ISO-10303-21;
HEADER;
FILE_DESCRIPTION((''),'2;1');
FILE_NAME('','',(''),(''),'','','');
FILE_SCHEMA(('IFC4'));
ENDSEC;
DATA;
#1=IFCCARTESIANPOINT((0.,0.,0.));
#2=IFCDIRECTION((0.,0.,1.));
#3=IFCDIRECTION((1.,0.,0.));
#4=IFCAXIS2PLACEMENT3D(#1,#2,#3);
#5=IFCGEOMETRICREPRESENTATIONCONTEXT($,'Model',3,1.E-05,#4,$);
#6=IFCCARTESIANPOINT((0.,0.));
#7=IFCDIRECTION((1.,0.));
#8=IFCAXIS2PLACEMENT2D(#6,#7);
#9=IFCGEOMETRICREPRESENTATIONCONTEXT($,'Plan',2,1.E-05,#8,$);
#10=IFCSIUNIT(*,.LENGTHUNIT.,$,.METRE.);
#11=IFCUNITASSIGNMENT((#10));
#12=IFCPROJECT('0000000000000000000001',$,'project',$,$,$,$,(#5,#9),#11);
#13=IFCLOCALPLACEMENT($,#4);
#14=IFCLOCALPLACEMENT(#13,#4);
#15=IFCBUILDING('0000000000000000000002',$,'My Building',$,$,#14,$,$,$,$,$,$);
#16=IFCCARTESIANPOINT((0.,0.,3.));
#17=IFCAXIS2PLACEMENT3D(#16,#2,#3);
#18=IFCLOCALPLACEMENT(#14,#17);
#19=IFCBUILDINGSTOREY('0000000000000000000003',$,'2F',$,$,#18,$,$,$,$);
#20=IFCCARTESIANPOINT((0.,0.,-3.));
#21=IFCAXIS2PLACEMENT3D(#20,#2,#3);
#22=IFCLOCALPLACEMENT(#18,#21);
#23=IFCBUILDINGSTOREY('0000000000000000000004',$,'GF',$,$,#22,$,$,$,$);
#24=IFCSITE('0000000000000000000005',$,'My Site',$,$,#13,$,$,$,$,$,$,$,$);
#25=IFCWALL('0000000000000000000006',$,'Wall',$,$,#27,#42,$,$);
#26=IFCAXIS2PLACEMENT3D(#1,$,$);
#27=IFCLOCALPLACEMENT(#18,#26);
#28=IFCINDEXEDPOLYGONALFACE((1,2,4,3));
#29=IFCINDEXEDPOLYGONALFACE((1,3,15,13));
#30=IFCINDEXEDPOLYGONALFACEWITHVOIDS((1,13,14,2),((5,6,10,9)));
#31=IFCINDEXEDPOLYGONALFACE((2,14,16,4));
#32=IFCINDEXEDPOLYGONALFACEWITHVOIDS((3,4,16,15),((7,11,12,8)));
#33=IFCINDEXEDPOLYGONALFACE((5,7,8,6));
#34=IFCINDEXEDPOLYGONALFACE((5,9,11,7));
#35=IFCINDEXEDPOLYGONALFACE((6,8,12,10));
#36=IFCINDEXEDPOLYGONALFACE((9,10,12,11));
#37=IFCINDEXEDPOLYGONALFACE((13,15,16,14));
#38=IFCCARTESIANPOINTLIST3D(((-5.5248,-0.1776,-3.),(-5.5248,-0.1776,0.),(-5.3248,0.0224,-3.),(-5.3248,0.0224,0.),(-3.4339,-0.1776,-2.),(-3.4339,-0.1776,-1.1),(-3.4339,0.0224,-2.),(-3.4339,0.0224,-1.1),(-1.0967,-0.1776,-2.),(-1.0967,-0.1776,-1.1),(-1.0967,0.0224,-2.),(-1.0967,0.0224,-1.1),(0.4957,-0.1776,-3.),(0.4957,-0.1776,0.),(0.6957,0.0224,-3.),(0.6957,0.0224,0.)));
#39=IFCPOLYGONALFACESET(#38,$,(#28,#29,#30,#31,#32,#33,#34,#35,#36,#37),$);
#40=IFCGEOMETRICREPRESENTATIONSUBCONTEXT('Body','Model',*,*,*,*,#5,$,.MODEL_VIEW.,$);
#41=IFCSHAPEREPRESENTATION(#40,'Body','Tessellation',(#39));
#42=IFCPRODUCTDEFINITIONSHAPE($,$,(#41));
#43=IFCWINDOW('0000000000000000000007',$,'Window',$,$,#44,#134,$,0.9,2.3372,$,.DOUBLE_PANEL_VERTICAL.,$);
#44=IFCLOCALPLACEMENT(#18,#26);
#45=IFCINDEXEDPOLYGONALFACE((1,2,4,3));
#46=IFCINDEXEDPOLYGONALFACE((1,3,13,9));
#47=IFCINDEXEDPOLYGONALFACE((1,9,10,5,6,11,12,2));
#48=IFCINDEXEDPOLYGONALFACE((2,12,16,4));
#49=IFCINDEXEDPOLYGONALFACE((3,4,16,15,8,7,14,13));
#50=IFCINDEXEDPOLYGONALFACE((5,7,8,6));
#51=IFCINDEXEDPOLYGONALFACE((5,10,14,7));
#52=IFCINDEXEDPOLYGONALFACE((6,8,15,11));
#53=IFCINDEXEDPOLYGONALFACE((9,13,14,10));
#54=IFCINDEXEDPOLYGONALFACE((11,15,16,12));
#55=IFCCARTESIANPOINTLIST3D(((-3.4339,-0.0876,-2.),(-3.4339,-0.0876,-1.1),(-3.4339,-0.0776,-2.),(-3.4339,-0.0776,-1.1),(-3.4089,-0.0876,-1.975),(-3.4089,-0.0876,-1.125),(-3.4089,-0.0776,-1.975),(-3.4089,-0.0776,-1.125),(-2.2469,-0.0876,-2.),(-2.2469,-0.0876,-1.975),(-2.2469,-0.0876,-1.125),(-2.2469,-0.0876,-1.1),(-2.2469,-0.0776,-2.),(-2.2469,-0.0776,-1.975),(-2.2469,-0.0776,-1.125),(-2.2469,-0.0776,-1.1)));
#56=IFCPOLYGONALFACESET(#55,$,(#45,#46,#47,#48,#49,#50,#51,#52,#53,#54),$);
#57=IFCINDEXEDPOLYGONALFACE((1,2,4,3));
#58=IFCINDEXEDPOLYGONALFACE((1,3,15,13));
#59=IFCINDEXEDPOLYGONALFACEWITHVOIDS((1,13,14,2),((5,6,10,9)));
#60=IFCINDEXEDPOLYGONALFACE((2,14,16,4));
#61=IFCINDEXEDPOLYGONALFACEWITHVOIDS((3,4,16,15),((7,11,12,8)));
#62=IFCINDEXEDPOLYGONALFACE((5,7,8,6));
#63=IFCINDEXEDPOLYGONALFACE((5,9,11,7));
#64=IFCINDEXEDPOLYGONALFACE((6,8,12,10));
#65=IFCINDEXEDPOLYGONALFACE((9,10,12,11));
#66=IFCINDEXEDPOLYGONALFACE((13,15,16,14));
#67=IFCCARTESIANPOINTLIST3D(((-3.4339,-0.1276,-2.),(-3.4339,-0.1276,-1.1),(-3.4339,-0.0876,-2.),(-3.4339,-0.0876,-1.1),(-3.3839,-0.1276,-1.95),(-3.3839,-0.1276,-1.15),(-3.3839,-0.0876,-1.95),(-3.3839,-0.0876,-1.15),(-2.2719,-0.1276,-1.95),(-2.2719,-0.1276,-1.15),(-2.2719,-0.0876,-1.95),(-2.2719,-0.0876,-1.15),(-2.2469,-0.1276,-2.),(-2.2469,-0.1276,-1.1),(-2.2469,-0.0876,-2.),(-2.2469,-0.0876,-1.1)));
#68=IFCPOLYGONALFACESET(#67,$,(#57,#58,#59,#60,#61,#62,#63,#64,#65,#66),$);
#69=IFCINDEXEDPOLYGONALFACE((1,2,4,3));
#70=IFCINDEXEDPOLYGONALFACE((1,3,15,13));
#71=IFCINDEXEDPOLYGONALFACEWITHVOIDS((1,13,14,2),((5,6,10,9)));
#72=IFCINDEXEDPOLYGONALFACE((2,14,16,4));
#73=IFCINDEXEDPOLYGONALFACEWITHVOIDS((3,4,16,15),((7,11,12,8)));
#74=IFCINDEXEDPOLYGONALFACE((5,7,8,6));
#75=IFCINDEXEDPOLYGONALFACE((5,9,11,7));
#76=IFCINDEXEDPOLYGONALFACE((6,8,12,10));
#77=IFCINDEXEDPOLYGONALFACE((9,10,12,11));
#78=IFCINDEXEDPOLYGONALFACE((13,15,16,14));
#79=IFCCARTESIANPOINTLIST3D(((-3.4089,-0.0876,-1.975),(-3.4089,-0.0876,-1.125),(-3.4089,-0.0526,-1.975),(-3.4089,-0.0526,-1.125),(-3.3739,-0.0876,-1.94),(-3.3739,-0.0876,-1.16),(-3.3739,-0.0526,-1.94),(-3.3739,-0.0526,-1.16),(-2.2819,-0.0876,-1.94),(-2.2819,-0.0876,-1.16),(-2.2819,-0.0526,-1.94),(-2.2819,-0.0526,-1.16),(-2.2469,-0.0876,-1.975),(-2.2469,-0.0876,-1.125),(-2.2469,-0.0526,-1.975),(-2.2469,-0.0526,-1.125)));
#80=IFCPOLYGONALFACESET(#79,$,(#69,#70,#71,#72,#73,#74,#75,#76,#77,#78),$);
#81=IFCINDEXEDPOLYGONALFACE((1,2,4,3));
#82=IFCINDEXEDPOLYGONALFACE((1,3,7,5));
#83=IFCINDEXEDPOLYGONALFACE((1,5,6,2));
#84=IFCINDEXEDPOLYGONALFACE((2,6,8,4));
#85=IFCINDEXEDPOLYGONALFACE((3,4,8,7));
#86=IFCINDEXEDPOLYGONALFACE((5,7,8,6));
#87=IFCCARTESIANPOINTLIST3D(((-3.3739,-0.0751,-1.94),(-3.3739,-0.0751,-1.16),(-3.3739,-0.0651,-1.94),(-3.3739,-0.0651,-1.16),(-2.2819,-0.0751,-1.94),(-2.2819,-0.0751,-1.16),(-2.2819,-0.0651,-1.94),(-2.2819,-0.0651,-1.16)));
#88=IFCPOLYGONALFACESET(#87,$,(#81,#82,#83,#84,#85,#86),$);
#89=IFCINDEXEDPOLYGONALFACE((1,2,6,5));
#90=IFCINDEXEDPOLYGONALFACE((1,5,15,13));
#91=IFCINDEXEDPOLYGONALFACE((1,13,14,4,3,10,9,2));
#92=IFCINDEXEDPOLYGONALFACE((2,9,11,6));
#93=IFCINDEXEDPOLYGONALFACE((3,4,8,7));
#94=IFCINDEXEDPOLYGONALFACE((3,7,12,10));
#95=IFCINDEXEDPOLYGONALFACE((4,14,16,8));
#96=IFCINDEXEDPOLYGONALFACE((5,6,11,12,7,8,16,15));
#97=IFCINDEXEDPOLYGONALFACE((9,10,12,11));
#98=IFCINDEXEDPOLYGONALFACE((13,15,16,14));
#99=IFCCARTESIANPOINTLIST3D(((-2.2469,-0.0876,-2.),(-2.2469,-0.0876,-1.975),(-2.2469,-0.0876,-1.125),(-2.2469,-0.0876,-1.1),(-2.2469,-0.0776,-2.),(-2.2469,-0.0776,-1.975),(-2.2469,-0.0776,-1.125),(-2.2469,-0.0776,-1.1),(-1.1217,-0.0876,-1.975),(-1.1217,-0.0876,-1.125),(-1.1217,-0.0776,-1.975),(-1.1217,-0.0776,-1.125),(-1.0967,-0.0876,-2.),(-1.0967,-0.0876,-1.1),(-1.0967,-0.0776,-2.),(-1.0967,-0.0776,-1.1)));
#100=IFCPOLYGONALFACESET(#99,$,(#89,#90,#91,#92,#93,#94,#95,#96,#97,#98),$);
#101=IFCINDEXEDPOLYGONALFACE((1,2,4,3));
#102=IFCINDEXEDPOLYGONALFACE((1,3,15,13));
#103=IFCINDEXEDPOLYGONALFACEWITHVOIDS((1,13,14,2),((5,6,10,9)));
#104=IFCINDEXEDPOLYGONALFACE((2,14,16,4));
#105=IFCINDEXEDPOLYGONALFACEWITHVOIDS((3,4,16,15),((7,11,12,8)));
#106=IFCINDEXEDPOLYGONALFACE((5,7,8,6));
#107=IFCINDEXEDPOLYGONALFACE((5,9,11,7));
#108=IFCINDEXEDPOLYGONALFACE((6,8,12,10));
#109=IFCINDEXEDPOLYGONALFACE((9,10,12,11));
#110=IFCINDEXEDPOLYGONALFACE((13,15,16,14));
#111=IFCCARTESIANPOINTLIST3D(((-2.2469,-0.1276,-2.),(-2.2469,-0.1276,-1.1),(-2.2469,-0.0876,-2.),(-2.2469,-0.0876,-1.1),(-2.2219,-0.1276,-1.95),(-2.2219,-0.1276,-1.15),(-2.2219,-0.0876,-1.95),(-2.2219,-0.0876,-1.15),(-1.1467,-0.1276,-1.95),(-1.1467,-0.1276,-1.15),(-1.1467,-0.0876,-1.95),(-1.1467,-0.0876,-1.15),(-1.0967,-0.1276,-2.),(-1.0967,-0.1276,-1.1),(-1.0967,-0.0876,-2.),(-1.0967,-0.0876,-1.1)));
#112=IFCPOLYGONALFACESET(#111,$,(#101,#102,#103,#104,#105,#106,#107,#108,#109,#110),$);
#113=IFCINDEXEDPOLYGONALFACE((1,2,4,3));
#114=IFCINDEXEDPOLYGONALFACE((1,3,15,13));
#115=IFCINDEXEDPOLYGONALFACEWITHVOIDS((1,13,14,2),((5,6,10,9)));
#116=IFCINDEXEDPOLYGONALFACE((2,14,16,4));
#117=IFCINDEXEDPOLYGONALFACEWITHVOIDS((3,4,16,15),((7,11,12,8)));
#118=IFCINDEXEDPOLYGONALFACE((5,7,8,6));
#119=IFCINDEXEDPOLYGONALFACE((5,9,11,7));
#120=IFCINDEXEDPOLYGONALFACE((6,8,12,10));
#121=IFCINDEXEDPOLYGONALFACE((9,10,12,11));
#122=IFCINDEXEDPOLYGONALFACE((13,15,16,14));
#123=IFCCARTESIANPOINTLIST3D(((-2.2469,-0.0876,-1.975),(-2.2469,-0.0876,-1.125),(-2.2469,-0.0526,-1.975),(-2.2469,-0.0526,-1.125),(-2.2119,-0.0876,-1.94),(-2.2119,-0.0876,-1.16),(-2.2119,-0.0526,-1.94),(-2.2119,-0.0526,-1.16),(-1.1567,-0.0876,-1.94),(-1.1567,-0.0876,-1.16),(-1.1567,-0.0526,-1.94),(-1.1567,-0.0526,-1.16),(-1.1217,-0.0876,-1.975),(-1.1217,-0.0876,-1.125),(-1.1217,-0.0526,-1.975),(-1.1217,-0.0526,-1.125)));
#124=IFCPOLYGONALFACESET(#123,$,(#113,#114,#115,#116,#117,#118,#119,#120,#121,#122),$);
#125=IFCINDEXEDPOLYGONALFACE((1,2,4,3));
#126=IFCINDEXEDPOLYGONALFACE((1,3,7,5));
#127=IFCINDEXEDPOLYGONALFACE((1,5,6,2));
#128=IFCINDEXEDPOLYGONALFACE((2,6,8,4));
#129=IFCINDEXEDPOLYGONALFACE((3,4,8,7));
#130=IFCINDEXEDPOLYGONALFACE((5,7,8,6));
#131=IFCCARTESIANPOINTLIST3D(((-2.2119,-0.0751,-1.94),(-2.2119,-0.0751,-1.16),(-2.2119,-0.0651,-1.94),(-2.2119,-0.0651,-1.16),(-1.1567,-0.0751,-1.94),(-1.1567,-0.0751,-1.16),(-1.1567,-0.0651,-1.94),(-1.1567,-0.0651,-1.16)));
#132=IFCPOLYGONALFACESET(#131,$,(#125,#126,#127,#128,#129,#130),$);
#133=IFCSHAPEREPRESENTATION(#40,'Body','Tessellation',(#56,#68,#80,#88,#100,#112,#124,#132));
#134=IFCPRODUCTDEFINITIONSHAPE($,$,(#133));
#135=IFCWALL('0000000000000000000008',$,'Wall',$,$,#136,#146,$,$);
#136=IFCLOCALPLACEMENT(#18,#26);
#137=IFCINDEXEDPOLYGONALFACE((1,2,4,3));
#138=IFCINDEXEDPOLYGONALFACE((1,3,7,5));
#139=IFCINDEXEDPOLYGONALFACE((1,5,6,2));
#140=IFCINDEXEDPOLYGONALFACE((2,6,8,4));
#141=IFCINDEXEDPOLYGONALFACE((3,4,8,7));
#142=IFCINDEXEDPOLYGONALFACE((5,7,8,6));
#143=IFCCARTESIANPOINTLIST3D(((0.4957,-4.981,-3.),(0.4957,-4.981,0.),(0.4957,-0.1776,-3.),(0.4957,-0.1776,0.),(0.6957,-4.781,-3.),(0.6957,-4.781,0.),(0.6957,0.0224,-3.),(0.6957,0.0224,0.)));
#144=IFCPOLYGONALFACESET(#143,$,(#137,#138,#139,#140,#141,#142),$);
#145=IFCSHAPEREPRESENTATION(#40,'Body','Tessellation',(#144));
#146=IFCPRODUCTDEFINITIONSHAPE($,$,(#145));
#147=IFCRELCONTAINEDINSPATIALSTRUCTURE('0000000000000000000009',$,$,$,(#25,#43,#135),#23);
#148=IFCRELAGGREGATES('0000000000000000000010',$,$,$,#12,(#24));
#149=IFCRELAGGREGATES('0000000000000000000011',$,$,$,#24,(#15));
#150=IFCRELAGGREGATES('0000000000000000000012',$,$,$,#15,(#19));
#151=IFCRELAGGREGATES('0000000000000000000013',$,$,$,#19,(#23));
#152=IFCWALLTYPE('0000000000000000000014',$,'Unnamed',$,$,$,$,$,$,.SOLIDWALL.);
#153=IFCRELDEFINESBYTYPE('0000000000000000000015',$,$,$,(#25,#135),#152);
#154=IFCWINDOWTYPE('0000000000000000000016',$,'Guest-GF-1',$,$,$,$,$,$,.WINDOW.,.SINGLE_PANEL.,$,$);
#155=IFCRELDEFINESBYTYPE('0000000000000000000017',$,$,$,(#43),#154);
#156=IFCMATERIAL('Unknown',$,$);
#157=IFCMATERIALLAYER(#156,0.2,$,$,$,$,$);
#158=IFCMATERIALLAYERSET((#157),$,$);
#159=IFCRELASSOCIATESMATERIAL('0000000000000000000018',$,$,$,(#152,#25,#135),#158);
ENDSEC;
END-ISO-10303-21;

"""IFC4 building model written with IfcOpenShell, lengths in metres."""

from ifc_helpers import new_model, entity, si_unit, frame, origin_with_axes, origin_2d_with_axis, place, context, subcontext, project, spatial, line, indexed_curve, outline, extrude, shape, source, transform, mapped, material, layer, layer_set, layer_usage, type_object, type_shapes, element, fill, save


model = new_model("IFC4")

# Units and contexts
model_context = context("Model", 3, precision=1e-05, world=origin_with_axes())
plan_context = context("Plan", 2, precision=1e-05, world=origin_2d_with_axis())
body_context_1 = subcontext(model_context, "Body", "Model", "MODEL_VIEW")
body_context_2 = subcontext(plan_context, "Body", "Plan", "PLAN_VIEW")
ifc_project = project(units=[si_unit("LENGTHUNIT", "METRE")], contexts=[model_context, plan_context])

# Site, building, storeys
site_placement = place(None, origin_with_axes())
site = spatial("IfcSite", under=ifc_project, at=site_placement, Name="My Site")
building_placement = place(site_placement, origin_with_axes())
building = spatial("IfcBuilding", under=site, at=building_placement, Name="My Building")
storey_1_placement = place(building_placement, frame((0.0, 0.0, 3.0), z_axis=(0.0, 0.0, 1.0), x_axis=(1.0, 0.0, 0.0)))
storey_1 = spatial("IfcBuildingStorey", under=building, at=storey_1_placement, Name="2F")
storey_2_placement = place(storey_1_placement, frame((0.0, 0.0, -3.0), z_axis=(0.0, 0.0, 1.0), x_axis=(1.0, 0.0, 0.0)))
storey_2 = spatial("IfcBuildingStorey", under=storey_1, at=storey_2_placement, Name="GF")

# Shared definitions
ifc_material = material(Name="Unknown")

# Shared definitions
ifc_layer_1 = layer(ifc_material, 0.2)
ifc_layer_set_1 = layer_set([ifc_layer_1])
wall_type = type_object("IfcWallType", Name="Unnamed", PredefinedType="SOLIDWALL", material=ifc_layer_set_1)

# Wall, opening, window
ifc_layer_usage_1 = layer_usage(ifc_layer_set_1, "AXIS2", "POSITIVE", 0.0)
wall_1_placement = place(storey_2_placement, frame((-5.5248, -0.1776, 0.0), z_axis=(0.0, 0.0, 1.0), x_axis=(1.0, 0.0, 0.0)))
wall_1 = element("IfcWall", 1, at=wall_1_placement, inside=storey_2, type_object=wall_type, material=ifc_layer_usage_1, Name="Wall", context=body_context_1, shape_type="SweptSolid", body=[
    extrude(outline(indexed_curve([(0.0, 0.0), (0.2, 0.2), (6.2205, 0.2), (6.0205, 0.0)], segments=[line(1, 2, 3, 4, 1)])), origin_with_axes(), (0.0, 0.0, 1.0), 3.0),
])
shared_shape_1 = source(origin_with_axes(), body_context_1, "Body", "SweptSolid", [
    extrude(outline(indexed_curve([(0.0, 0.0), (2.3372, 0.0), (2.3372, 0.9), (0.0, 0.9)], segments=[line(1, 2, 3, 4, 1)])), frame((0.0, -0.6, 0.0), z_axis=(0.0, -1.0, 0.0), x_axis=(1.0, 0.0, 0.0)), (0.0, 0.0, -1.0), 1.2),
])
opening_1_placement = place(wall_1_placement, frame((2.0909, 0.0, 1.0), z_axis=(0.0, 0.0, 1.0), x_axis=(1.0, 0.0, 0.0)))
opening_1 = element("IfcOpeningElement", 2, at=opening_1_placement, cuts=wall_1, PredefinedType="OPENING", context=body_context_1, shape_type="MappedRepresentation", body=[
    mapped(shared_shape_1, transform((0.0, 0.0, 0.0), x_axis=(1.0, 0.0, 0.0), y_axis=(0.0, 1.0, 0.0), z_axis=(0.0, 0.0, 1.0), scale=1.0)),
])
window_type_1 = type_object("IfcWindowType", Name="Guest-GF-1", PartitioningType="SINGLE_PANEL", PredefinedType="WINDOW")
shared_shape_2 = source(origin_with_axes(), body_context_1, "Body", "SweptSolid", [
    extrude(outline(indexed_curve([(1.187, 0.0), (0.0, 0.0), (0.0, 0.9), (1.187, 0.9), (1.187, 0.875), (0.025, 0.875), (0.025, 0.025), (1.187, 0.025)], segments=[line(1, 2, 3, 4, 5, 6, 7, 8, 1)])), frame((0.0, 0.09, 0.0), z_axis=(0.0, -1.0, 0.0), x_axis=(1.0, 0.0, 0.0)), (0.0, 0.0, -1.0), 0.01),
    extrude(outline(indexed_curve([(0.0, 0.0), (1.187, 0.0), (1.187, 0.9), (0.0, 0.9)], segments=[line(1, 2, 3, 4, 1)]), holes=[indexed_curve([(0.05, 0.05), (1.162, 0.05), (1.162, 0.85), (0.05, 0.85)], segments=[line(1, 2, 3, 4, 1)])]), frame((0.0, 0.05, 0.0), z_axis=(0.0, -1.0, 0.0), x_axis=(1.0, 0.0, 0.0)), (0.0, 0.0, -1.0), 0.04),
    extrude(outline(indexed_curve([(0.0, 0.0), (1.162, 0.0), (1.162, 0.85), (0.0, 0.85)], segments=[line(1, 2, 3, 4, 1)]), holes=[indexed_curve([(0.035, 0.035), (1.127, 0.035), (1.127, 0.815), (0.035, 0.815)], segments=[line(1, 2, 3, 4, 1)])]), frame((0.025, 0.09, 0.025), z_axis=(0.0, -1.0, 0.0), x_axis=(1.0, 0.0, 0.0)), (0.0, 0.0, -1.0), 0.035),
    extrude(outline(indexed_curve([(0.035, 0.035), (1.127, 0.035), (1.127, 0.815), (0.035, 0.815)], segments=[line(1, 2, 3, 4, 1)])), frame((0.025, 0.1025, 0.025), z_axis=(0.0, -1.0, 0.0), x_axis=(1.0, 0.0, 0.0)), (0.0, 0.0, -1.0), 0.01),
    extrude(outline(indexed_curve([(0.0, 0.9), (1.1502, 0.9), (1.1502, 0.0), (0.0, 0.0), (0.0, 0.025), (1.1252, 0.025), (1.1252, 0.875), (0.0, 0.875)], segments=[line(1, 2, 3, 4, 5, 6, 7, 8, 1)])), frame((1.187, 0.09, 0.0), z_axis=(0.0, -1.0, 0.0), x_axis=(1.0, 0.0, 0.0)), (0.0, 0.0, -1.0), 0.01),
    extrude(outline(indexed_curve([(0.0, 0.0), (1.1502, 0.0), (1.1502, 0.9), (0.0, 0.9)], segments=[line(1, 2, 3, 4, 1)]), holes=[indexed_curve([(0.025, 0.05), (1.1002, 0.05), (1.1002, 0.85), (0.025, 0.85)], segments=[line(1, 2, 3, 4, 1)])]), frame((1.187, 0.05, 0.0), z_axis=(0.0, -1.0, 0.0), x_axis=(1.0, 0.0, 0.0)), (0.0, 0.0, -1.0), 0.04),
    extrude(outline(indexed_curve([(0.0, 0.0), (1.1252, 0.0), (1.1252, 0.85), (0.0, 0.85)], segments=[line(1, 2, 3, 4, 1)]), holes=[indexed_curve([(0.035, 0.035), (1.0902, 0.035), (1.0902, 0.815), (0.035, 0.815)], segments=[line(1, 2, 3, 4, 1)])]), frame((1.187, 0.09, 0.025), z_axis=(0.0, -1.0, 0.0), x_axis=(1.0, 0.0, 0.0)), (0.0, 0.0, -1.0), 0.035),
    extrude(outline(indexed_curve([(0.035, 0.035), (1.0902, 0.035), (1.0902, 0.815), (0.035, 0.815)], segments=[line(1, 2, 3, 4, 1)])), frame((1.187, 0.1025, 0.025), z_axis=(0.0, -1.0, 0.0), x_axis=(1.0, 0.0, 0.0)), (0.0, 0.0, -1.0), 0.01),
])
shared_shape_3 = source(origin_with_axes(), body_context_2, "Body", "Curve2D", [
    entity("IfcIndexedPolyCurve", entity("IfcCartesianPointList2D", [[0.05, 0.05], [1.162, 0.05]])),
    entity("IfcIndexedPolyCurve", entity("IfcCartesianPointList2D", [[0.0, 0.1], [0.025, 0.1], [0.025, 0.09], [0.05, 0.09], [0.05, 0.05], [0.0, 0.05]]), [entity("IfcLineIndex", [1, 2, 3, 4, 5, 6, 1])]),
    entity("IfcIndexedPolyCurve", entity("IfcCartesianPointList2D", [[1.187, 0.1], [1.187, 0.1], [1.187, 0.09], [1.162, 0.09], [1.162, 0.05], [1.187, 0.05]])),
    entity("IfcIndexedPolyCurve", entity("IfcCartesianPointList2D", [[0.025, 0.09], [0.06, 0.09], [0.06, 0.125], [0.025, 0.125]]), [entity("IfcLineIndex", [1, 2, 3, 4, 1])]),
    entity("IfcIndexedPolyCurve", entity("IfcCartesianPointList2D", [[1.187, 0.09], [1.152, 0.09], [1.152, 0.125], [1.187, 0.125]]), [entity("IfcLineIndex", [1, 2, 3, 4, 1])]),
    entity("IfcIndexedPolyCurve", entity("IfcCartesianPointList2D", [[0.06, 0.09], [1.152, 0.09]])),
    entity("IfcIndexedPolyCurve", entity("IfcCartesianPointList2D", [[0.06, 0.125], [1.152, 0.125]])),
    entity("IfcIndexedPolyCurve", entity("IfcCartesianPointList2D", [[0.06, 0.1075], [1.152, 0.1075]])),
    entity("IfcIndexedPolyCurve", entity("IfcCartesianPointList2D", [[1.212, 0.05], [2.2872, 0.05]])),
    entity("IfcIndexedPolyCurve", entity("IfcCartesianPointList2D", [[1.187, 0.1], [1.187, 0.1], [1.187, 0.09], [1.212, 0.09], [1.212, 0.05], [1.187, 0.05]])),
    entity("IfcIndexedPolyCurve", entity("IfcCartesianPointList2D", [[2.3372, 0.1], [2.3122, 0.1], [2.3122, 0.09], [2.2872, 0.09], [2.2872, 0.05], [2.3372, 0.05]]), [entity("IfcLineIndex", [1, 2, 3, 4, 5, 6, 1])]),
    entity("IfcIndexedPolyCurve", entity("IfcCartesianPointList2D", [[1.187, 0.09], [1.222, 0.09], [1.222, 0.125], [1.187, 0.125]]), [entity("IfcLineIndex", [1, 2, 3, 4, 1])]),
    entity("IfcIndexedPolyCurve", entity("IfcCartesianPointList2D", [[2.3122, 0.09], [2.2772, 0.09], [2.2772, 0.125], [2.3122, 0.125]]), [entity("IfcLineIndex", [1, 2, 3, 4, 1])]),
    entity("IfcIndexedPolyCurve", entity("IfcCartesianPointList2D", [[1.222, 0.09], [2.2772, 0.09]])),
    entity("IfcIndexedPolyCurve", entity("IfcCartesianPointList2D", [[1.222, 0.125], [2.2772, 0.125]])),
    entity("IfcIndexedPolyCurve", entity("IfcCartesianPointList2D", [[1.222, 0.1075], [2.2772, 0.1075]])),
])
type_shapes(window_type_1, [shared_shape_2, shared_shape_3])
window_1_placement = place(opening_1_placement, origin_with_axes())
window_1 = element("IfcWindow", 3, at=window_1_placement, inside=storey_2, type_object=window_type_1, Name="Window", OverallHeight=0.9, OverallWidth=2.3372, PartitioningType="DOUBLE_PANEL_VERTICAL", shapes=[
    shape(body_context_1, "Body", "MappedRepresentation", [mapped(shared_shape_2, transform((0.0, 0.0, 0.0), x_axis=(1.0, 0.0, 0.0), y_axis=(0.0, 1.0, 0.0), z_axis=(0.0, 0.0, 1.0), scale=1.0))]),
    shape(body_context_2, "Body", "MappedRepresentation", [mapped(shared_shape_3, transform((0.0, 0.0, 0.0), x_axis=(1.0, 0.0, 0.0), y_axis=(0.0, 1.0, 0.0), z_axis=(0.0, 0.0, 1.0), scale=1.0))]),
])
fill(opening_1, window_1)

# Wall
ifc_layer_usage_2 = layer_usage(ifc_layer_set_1, "AXIS2", "POSITIVE", 0.0)
wall_2_placement = place(storey_2_placement, frame((0.4957, -0.1776, 0.0), z_axis=(0.0, 0.0, 1.0), x_axis=(0.0, -1.0, 0.0)))
element("IfcWall", 4, at=wall_2_placement, inside=storey_2, type_object=wall_type, material=ifc_layer_usage_2, Name="Wall", context=body_context_1, shape_type="SweptSolid", body=[
    extrude(outline(indexed_curve([(0.0, 0.0), (-0.2, 0.2), (4.6033, 0.2), (4.8033, 0.0)], segments=[line(1, 2, 3, 4, 1)])), origin_with_axes(), (0.0, 0.0, 1.0), 3.0),
])

save(model, "model.ifc")
